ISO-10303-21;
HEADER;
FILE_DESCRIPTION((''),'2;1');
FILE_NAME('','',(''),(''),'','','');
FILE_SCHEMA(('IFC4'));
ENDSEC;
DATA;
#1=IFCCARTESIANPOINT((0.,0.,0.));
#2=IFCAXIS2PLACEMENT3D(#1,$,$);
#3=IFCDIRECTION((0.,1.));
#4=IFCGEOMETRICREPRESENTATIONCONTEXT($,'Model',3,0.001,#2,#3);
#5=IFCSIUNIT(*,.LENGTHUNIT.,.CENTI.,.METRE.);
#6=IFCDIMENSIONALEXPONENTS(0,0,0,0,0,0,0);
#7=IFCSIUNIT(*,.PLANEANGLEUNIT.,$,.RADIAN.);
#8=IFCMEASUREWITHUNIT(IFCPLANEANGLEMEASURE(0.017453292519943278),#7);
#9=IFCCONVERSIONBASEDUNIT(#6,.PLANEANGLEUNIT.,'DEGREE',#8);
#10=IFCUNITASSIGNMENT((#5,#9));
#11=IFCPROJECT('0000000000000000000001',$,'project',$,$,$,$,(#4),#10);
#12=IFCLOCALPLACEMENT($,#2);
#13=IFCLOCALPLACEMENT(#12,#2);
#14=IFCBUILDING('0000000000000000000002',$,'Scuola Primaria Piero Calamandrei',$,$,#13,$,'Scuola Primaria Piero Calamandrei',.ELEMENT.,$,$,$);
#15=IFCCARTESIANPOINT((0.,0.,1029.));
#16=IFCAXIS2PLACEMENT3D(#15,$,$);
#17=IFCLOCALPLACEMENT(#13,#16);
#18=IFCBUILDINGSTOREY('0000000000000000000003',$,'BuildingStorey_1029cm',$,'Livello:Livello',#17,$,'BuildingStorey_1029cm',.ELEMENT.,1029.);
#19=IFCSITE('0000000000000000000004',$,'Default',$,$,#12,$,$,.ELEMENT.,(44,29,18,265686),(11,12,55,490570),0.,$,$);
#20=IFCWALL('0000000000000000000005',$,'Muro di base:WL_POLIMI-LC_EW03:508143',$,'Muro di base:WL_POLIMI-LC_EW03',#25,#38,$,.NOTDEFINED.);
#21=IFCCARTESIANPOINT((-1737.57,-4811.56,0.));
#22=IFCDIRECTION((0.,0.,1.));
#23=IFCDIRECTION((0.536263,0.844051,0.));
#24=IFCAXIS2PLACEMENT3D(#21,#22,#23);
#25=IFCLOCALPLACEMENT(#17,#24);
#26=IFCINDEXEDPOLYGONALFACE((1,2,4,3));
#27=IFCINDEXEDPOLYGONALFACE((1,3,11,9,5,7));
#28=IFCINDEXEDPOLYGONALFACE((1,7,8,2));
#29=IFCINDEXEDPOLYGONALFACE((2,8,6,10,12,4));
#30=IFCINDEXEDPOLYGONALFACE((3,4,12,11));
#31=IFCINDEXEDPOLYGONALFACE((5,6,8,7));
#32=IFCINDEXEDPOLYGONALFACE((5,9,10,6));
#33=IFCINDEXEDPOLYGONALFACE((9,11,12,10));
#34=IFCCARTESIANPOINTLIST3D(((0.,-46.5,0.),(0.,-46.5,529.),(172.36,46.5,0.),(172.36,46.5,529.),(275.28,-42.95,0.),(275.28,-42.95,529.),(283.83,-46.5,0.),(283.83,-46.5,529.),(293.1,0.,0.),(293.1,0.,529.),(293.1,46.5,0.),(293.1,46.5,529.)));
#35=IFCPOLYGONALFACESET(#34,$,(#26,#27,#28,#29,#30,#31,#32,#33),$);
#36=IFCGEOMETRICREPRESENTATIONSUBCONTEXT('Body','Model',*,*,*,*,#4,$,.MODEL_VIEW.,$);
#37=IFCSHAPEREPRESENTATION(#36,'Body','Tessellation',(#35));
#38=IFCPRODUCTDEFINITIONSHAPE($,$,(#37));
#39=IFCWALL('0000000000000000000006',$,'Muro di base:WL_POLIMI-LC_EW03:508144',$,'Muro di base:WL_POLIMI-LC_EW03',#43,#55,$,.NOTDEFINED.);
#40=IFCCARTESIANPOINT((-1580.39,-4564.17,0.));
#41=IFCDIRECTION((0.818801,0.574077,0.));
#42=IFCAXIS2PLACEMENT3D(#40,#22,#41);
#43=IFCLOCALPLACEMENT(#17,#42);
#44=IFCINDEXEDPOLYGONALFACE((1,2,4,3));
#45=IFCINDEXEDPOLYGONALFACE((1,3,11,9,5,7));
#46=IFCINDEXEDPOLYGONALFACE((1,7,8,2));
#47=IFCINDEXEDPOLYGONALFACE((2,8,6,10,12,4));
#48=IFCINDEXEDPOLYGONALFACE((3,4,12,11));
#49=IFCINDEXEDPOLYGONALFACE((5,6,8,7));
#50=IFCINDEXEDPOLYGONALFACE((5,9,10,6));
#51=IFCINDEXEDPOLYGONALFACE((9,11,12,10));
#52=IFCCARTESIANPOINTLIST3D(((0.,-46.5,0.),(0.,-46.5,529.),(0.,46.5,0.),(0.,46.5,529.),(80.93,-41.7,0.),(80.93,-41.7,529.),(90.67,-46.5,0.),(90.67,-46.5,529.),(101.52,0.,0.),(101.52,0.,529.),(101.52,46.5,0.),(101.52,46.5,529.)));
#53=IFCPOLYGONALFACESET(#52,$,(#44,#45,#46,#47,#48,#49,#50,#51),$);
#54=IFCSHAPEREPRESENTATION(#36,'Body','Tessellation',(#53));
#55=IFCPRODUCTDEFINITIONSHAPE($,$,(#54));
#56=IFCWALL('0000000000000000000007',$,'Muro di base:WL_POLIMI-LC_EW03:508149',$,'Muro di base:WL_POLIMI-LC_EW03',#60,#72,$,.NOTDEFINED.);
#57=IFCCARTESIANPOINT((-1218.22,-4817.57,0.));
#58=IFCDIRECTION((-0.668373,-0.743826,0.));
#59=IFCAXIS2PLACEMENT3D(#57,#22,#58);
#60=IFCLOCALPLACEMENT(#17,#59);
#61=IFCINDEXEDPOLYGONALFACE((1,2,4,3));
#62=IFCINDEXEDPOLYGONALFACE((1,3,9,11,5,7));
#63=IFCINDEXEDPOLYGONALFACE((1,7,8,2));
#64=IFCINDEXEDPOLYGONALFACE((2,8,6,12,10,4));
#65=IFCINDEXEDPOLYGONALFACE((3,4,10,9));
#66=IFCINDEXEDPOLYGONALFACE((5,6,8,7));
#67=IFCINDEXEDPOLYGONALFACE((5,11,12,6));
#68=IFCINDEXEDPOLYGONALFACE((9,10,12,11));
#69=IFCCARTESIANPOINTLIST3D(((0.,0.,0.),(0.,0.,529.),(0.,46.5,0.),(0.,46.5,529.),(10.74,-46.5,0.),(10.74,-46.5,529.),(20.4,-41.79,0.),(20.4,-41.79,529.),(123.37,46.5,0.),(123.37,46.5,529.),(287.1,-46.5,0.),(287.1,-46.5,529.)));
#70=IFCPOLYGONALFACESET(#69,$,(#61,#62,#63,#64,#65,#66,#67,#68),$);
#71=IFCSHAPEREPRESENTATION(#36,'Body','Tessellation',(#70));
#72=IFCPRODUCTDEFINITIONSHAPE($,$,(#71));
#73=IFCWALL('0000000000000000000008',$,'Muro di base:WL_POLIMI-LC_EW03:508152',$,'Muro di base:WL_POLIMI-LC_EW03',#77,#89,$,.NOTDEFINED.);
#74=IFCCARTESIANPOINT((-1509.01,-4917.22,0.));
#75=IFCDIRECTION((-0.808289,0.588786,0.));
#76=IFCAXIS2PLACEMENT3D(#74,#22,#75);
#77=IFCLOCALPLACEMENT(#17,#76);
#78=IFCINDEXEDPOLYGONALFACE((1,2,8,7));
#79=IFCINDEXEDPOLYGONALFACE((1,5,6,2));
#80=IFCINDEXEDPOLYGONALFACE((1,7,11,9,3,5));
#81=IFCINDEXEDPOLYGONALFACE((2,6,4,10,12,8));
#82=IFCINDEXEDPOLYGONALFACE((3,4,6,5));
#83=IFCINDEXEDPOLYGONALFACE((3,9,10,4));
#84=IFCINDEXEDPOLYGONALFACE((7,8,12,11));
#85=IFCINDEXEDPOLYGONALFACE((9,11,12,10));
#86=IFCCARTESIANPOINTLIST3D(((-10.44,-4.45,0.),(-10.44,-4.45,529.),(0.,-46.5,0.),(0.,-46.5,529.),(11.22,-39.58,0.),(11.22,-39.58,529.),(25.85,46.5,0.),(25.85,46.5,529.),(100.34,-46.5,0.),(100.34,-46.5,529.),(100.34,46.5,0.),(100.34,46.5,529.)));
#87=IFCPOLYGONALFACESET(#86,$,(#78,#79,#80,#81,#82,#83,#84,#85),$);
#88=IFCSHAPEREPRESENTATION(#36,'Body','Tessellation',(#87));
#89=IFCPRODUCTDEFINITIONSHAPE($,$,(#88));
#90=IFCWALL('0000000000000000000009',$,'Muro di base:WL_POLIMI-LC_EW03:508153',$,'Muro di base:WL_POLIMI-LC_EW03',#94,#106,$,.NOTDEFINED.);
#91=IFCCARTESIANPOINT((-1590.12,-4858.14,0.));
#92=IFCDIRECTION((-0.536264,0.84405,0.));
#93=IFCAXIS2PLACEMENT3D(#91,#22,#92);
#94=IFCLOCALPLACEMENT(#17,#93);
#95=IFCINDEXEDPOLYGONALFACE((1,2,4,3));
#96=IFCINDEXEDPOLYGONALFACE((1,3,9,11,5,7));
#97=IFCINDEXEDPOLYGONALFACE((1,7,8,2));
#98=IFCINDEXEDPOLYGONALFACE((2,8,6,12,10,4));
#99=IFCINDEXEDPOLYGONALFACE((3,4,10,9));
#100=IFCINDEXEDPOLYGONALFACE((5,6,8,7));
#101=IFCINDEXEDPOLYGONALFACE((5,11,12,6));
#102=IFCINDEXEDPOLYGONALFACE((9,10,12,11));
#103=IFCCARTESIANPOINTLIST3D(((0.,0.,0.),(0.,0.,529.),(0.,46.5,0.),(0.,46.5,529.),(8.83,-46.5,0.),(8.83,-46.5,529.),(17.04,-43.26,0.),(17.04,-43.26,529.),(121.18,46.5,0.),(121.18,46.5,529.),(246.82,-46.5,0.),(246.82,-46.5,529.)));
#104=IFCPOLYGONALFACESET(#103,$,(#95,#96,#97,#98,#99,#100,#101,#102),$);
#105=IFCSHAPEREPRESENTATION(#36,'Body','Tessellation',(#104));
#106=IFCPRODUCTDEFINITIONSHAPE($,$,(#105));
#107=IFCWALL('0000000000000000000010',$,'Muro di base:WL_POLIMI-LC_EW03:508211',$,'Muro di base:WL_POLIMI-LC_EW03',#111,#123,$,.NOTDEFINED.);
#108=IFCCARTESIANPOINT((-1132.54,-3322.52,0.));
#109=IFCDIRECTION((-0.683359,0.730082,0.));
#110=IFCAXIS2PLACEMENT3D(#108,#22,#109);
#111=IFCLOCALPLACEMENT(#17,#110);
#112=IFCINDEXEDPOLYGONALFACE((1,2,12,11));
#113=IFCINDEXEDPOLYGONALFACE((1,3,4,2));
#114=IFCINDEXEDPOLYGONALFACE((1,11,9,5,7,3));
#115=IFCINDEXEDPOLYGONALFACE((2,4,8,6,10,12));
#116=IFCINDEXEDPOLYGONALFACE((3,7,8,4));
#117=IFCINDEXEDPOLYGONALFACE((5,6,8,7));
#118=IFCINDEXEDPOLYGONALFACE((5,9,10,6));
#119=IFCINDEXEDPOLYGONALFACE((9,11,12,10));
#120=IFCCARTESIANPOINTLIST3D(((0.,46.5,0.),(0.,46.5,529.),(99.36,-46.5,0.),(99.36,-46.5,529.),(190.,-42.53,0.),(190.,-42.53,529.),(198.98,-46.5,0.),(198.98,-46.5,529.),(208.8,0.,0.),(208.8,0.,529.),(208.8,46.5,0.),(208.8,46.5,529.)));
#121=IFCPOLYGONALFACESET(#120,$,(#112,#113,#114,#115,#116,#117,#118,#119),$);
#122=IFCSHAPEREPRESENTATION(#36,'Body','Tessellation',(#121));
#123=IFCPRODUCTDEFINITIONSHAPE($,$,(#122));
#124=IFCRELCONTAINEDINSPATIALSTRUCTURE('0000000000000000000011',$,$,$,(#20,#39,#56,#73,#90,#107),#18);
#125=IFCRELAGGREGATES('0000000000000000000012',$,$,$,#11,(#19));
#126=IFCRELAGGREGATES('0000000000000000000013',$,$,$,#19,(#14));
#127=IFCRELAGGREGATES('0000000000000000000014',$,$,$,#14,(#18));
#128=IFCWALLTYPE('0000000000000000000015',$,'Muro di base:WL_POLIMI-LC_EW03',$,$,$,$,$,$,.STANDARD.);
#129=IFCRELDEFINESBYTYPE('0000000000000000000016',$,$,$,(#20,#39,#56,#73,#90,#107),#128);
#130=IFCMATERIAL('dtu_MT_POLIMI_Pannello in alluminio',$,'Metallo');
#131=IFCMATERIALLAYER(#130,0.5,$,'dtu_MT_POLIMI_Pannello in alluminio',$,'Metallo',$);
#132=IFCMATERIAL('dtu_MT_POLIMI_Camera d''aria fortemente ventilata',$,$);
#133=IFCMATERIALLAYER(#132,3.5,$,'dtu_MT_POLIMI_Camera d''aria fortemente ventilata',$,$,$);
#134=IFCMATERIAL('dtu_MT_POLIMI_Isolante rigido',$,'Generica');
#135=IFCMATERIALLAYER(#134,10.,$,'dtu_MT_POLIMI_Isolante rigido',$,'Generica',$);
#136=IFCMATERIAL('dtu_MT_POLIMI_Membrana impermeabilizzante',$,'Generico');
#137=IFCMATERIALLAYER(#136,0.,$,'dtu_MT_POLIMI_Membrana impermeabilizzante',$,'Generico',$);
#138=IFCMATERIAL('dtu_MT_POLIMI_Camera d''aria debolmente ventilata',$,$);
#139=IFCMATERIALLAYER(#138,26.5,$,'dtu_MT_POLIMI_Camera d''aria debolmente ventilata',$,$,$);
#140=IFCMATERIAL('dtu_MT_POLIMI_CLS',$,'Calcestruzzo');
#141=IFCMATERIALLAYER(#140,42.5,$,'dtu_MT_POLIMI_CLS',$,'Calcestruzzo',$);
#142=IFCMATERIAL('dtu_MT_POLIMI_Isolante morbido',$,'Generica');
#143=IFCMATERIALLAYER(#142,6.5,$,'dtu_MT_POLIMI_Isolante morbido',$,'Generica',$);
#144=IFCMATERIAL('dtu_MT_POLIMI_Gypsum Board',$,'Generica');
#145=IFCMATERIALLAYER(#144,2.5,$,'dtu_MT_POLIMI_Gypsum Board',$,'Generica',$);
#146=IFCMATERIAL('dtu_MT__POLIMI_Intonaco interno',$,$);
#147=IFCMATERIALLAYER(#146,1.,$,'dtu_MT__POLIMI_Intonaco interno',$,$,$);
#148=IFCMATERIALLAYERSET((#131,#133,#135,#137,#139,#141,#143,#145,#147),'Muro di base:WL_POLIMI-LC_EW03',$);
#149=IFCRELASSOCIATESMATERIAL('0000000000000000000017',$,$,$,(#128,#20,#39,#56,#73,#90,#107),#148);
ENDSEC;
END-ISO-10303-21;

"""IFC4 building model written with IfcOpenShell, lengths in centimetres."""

from ifc_helpers import new_model, entity, si_unit, converted_unit, direction, frame, frame_2d, origin, place, context, subcontext, project, spatial, polyline, rectangle, outline, extrude, clip, bounded_halfspace, material, layer, layer_set, layer_usage, type_object, element, save


model = new_model("IFC4")

# Units and contexts
model_context = context("Model", 3, precision=0.001, world=origin(), true_north=direction((0.0, 1.0)))
body_context = subcontext(model_context, "Body", "Model", "MODEL_VIEW")
ifc_project = project(units=[si_unit("LENGTHUNIT", "METRE", prefix="CENTI"), converted_unit("PLANEANGLEUNIT", "DEGREE", entity("IfcPlaneAngleMeasure", 0.017453292519943278), si_unit("PLANEANGLEUNIT", "RADIAN"), dimensions=[0, 0, 0, 0, 0, 0, 0])], contexts=[model_context])

# Site, building, storey
site_placement = place(None, origin())
site = spatial("IfcSite", under=ifc_project, at=site_placement, Name="Default", CompositionType="ELEMENT", RefLatitude=(44, 29, 18, 265686), RefLongitude=(11, 12, 55, 490570), RefElevation=0.0)
building_placement = place(site_placement, origin())
building = spatial("IfcBuilding", under=site, at=building_placement, Name="Scuola Primaria Piero Calamandrei", LongName="Scuola Primaria Piero Calamandrei", CompositionType="ELEMENT")
storey_placement = place(building_placement, frame((0.0, 0.0, 1029.0)))
storey = spatial("IfcBuildingStorey", under=building, at=storey_placement, Name="BuildingStorey_1029cm", ObjectType="Livello:Livello", LongName="BuildingStorey_1029cm", CompositionType="ELEMENT", Elevation=1029.0)

# Shared definitions
ifc_material_1 = material(Name="dtu_MT_POLIMI_Pannello in alluminio", Category="Metallo")
ifc_material_2 = material(Name="dtu_MT_POLIMI_Camera d'aria fortemente ventilata")
ifc_material_3 = material(Name="dtu_MT_POLIMI_Isolante rigido", Category="Generica")
ifc_material_4 = material(Name="dtu_MT_POLIMI_Membrana impermeabilizzante", Category="Generico")
ifc_material_5 = material(Name="dtu_MT_POLIMI_Camera d'aria debolmente ventilata")
ifc_material_6 = material(Name="dtu_MT_POLIMI_Isolante morbido", Category="Generica")
ifc_material_7 = material(Name="dtu_MT_POLIMI_Gypsum Board", Category="Generica")
ifc_material_8 = material(Name="dtu_MT__POLIMI_Intonaco interno")

# Walls
ifc_layer_1 = layer(ifc_material_1, 0.5, Name="dtu_MT_POLIMI_Pannello in alluminio", Category="Metallo")
ifc_layer_2 = layer(ifc_material_2, 3.5, Name="dtu_MT_POLIMI_Camera d'aria fortemente ventilata")
ifc_layer_3 = layer(ifc_material_3, 10.0, Name="dtu_MT_POLIMI_Isolante rigido", Category="Generica")
ifc_layer_4 = layer(ifc_material_4, 0.0, Name="dtu_MT_POLIMI_Membrana impermeabilizzante", Category="Generico")
ifc_layer_5 = layer(ifc_material_5, 26.5, Name="dtu_MT_POLIMI_Camera d'aria debolmente ventilata")
ifc_material_9 = material(Name="dtu_MT_POLIMI_CLS", Category="Calcestruzzo")
ifc_layer_6 = layer(ifc_material_9, 42.5, Name="dtu_MT_POLIMI_CLS", Category="Calcestruzzo")
ifc_layer_7 = layer(ifc_material_6, 6.5, Name="dtu_MT_POLIMI_Isolante morbido", Category="Generica")
ifc_layer_8 = layer(ifc_material_7, 2.5, Name="dtu_MT_POLIMI_Gypsum Board", Category="Generica")
ifc_layer_9 = layer(ifc_material_8, 1.0, Name="dtu_MT__POLIMI_Intonaco interno")
ifc_layer_set_1 = layer_set([ifc_layer_1, ifc_layer_2, ifc_layer_3, ifc_layer_4, ifc_layer_5, ifc_layer_6, ifc_layer_7, ifc_layer_8, ifc_layer_9], Name="Muro di base:WL_POLIMI-LC_EW03")
ifc_layer_usage_1 = layer_usage(ifc_layer_set_1, "AXIS2", "NEGATIVE", 46.5)
wall_type_1 = type_object("IfcWallType", Name="Muro di base:WL_POLIMI-LC_EW03", PredefinedType="STANDARD", material=ifc_layer_set_1)
wall_1_placement = place(storey_placement, frame((-1737.57, -4811.56, 0.0), z_axis=(0.0, 0.0, 1.0), x_axis=(0.536263, 0.844051, 0.0)))
element("IfcWall", 1, at=wall_1_placement, inside=storey, type_object=wall_type_1, material=ifc_layer_usage_1, Name="Muro di base:WL_POLIMI-LC_EW03:508143", ObjectType="Muro di base:WL_POLIMI-LC_EW03", PredefinedType="NOTDEFINED", context=body_context, shape_type="Clipping", body=[
    clip(clip(extrude(outline(polyline([(172.36, 46.5), (0.0, -46.5), (283.83, -46.5), (275.28, -42.95), (293.1, 0.0), (293.1, 46.5), (172.36, 46.5)])), origin(), (0.0, 0.0, 1.0), 529.0), bounded_halfspace(frame((275.28, -42.95, 0.0), z_axis=(-0.383253, -0.923643, 0.0), x_axis=(0.923643, -0.383253, 0.0)), True, frame((275.28, -42.95, 0.0), z_axis=(-0.383253, -0.923643, 0.0), x_axis=(0.923643, -0.383253, 0.0)), polyline([(0.0, 0.0), (282.38, 0.0), (282.38, 16123.93), (0.0, 16123.93), (0.0, 0.0)]))), bounded_halfspace(frame((275.28, -42.95, 529.0), z_axis=(-0.923643, 0.383253, 0.0), x_axis=(0.383253, 0.923643, 0.0)), True, frame((275.28, -42.95, 529.0), z_axis=(-0.923643, 0.383253, 0.0), x_axis=(0.383253, 0.923643, 0.0)), polyline([(0.0, 0.0), (1417.32, 0.0), (1417.32, 16123.93), (0.0, 16123.93), (0.0, 0.0)]))),
])
ifc_layer_usage_2 = layer_usage(ifc_layer_set_1, "AXIS2", "NEGATIVE", 46.5)
wall_2_placement = place(storey_placement, frame((-1580.39, -4564.17, 0.0), z_axis=(0.0, 0.0, 1.0), x_axis=(0.818801, 0.574077, 0.0)))
element("IfcWall", 2, at=wall_2_placement, inside=storey, type_object=wall_type_1, material=ifc_layer_usage_2, Name="Muro di base:WL_POLIMI-LC_EW03:508144", ObjectType="Muro di base:WL_POLIMI-LC_EW03", PredefinedType="NOTDEFINED", context=body_context, shape_type="Clipping", body=[
    clip(clip(extrude(rectangle(XDim=101.52, YDim=93.0, at=frame_2d((50.76, 0.0), x_axis=(-1.0, 0.0))), origin(), (0.0, 0.0, 1.0), 529.0), bounded_halfspace(frame((80.93, -41.7, 0.0), z_axis=(-0.442682, -0.896679, 0.0), x_axis=(0.896679, -0.442682, 0.0)), True, frame((80.93, -41.7, 0.0), z_axis=(-0.442682, -0.896679, 0.0), x_axis=(0.896679, -0.442682, 0.0)), polyline([(0.0, 0.0), (330.8, 0.0), (330.8, 16123.93), (0.0, 16123.93), (0.0, 0.0)]))), bounded_halfspace(frame((80.93, -41.7, 529.0), z_axis=(-0.896679, 0.442682, 0.0), x_axis=(0.442682, 0.896679, 0.0)), True, frame((80.93, -41.7, 529.0), z_axis=(-0.896679, 0.442682, 0.0), x_axis=(0.442682, 0.896679, 0.0)), polyline([(0.0, 0.0), (1417.32, 0.0), (1417.32, 16123.93), (0.0, 16123.93), (0.0, 0.0)]))),
])

# Walls
ifc_layer_usage_3 = layer_usage(ifc_layer_set_1, "AXIS2", "NEGATIVE", 46.5)
wall_3_placement = place(storey_placement, frame((-1218.22, -4817.57, 0.0), z_axis=(0.0, 0.0, 1.0), x_axis=(-0.668373, -0.743826, 0.0)))
element("IfcWall", 3, at=wall_3_placement, inside=storey, type_object=wall_type_1, material=ifc_layer_usage_3, Name="Muro di base:WL_POLIMI-LC_EW03:508149", ObjectType="Muro di base:WL_POLIMI-LC_EW03", PredefinedType="NOTDEFINED", context=body_context, shape_type="Clipping", body=[
    clip(clip(extrude(outline(polyline([(0.0, 46.5), (0.0, 0.0), (20.4, -41.79), (10.74, -46.5), (98.8, -46.5), (287.1, -46.5), (123.37, 46.5), (0.0, 46.5)])), origin(), (0.0, 0.0, 1.0), 529.0), bounded_halfspace(frame((20.4, -41.79, 529.0), z_axis=(0.438691, -0.898638, 0.0), x_axis=(0.898638, 0.438691, 0.0)), True, frame((20.4, -41.79, 529.0), z_axis=(0.438691, -0.898638, 0.0), x_axis=(0.898638, 0.438691, 0.0)), polyline([(0.0, 0.0), (-327.48, 0.0), (-327.48, -16123.93), (0.0, -16123.93), (0.0, 0.0)]))), bounded_halfspace(frame((20.4, -41.79, 0.0), z_axis=(0.898638, 0.438691, 0.0), x_axis=(-0.438691, 0.898638, 0.0)), True, frame((20.4, -41.79, 0.0), z_axis=(0.898638, 0.438691, 0.0), x_axis=(-0.438691, 0.898638, 0.0)), polyline([(0.0, 0.0), (1417.32, 0.0), (1417.32, 16123.93), (0.0, 16123.93), (0.0, 0.0)]))),
])
ifc_layer_usage_4 = layer_usage(ifc_layer_set_1, "AXIS2", "NEGATIVE", 46.5)
wall_4_placement = place(storey_placement, frame((-1509.01, -4917.22, 0.0), z_axis=(0.0, 0.0, 1.0), x_axis=(-0.808289, 0.588786, 0.0)))
element("IfcWall", 4, at=wall_4_placement, inside=storey, type_object=wall_type_1, material=ifc_layer_usage_4, Name="Muro di base:WL_POLIMI-LC_EW03:508152", ObjectType="Muro di base:WL_POLIMI-LC_EW03", PredefinedType="NOTDEFINED", context=body_context, shape_type="Clipping", body=[
    clip(clip(extrude(outline(polyline([(25.85, 46.5), (-10.44, -4.45), (11.22, -39.58), (0.0, -46.5), (91.51, -46.5), (100.34, -46.5), (100.34, 0.0), (100.34, 46.5), (25.85, 46.5)])), origin(), (0.0, 0.0, 1.0), 529.0), bounded_halfspace(frame((11.22, -39.58, 529.0), z_axis=(0.524953, -0.851131, 0.0), x_axis=(0.851131, 0.524953, 0.0)), True, frame((11.22, -39.58, 529.0), z_axis=(0.524953, -0.851131, 0.0), x_axis=(0.851131, 0.524953, 0.0)), polyline([(0.0, 0.0), (-401.93, 0.0), (-401.93, -16123.93), (0.0, -16123.93), (0.0, 0.0)]))), bounded_halfspace(frame((11.22, -39.58, 0.0), z_axis=(0.851131, 0.524953, 0.0), x_axis=(-0.524953, 0.851131, 0.0)), True, frame((11.22, -39.58, 0.0), z_axis=(0.851131, 0.524953, 0.0), x_axis=(-0.524953, 0.851131, 0.0)), polyline([(0.0, 0.0), (1258.06, 0.0), (1258.06, 16123.93), (0.0, 16123.93), (0.0, 0.0)]))),
])
ifc_layer_usage_5 = layer_usage(ifc_layer_set_1, "AXIS2", "NEGATIVE", 46.5)
wall_5_placement = place(storey_placement, frame((-1590.12, -4858.14, 0.0), z_axis=(0.0, 0.0, 1.0), x_axis=(-0.536264, 0.84405, 0.0)))
element("IfcWall", 5, at=wall_5_placement, inside=storey, type_object=wall_type_1, material=ifc_layer_usage_5, Name="Muro di base:WL_POLIMI-LC_EW03:508153", ObjectType="Muro di base:WL_POLIMI-LC_EW03", PredefinedType="NOTDEFINED", context=body_context, shape_type="Clipping", body=[
    clip(clip(extrude(outline(polyline([(0.0, 46.5), (0.0, 0.0), (17.04, -43.26), (8.83, -46.5), (246.82, -46.5), (121.18, 46.5), (0.0, 46.5)])), origin(), (0.0, 0.0, 1.0), 529.0), bounded_halfspace(frame((17.04, -43.26, 529.0), z_axis=(0.366492, -0.930421, 0.0), x_axis=(0.930421, 0.366492, 0.0)), True, frame((17.04, -43.26, 529.0), z_axis=(0.366492, -0.930421, 0.0), x_axis=(0.930421, 0.366492, 0.0)), polyline([(0.0, 0.0), (-269.08, 0.0), (-269.08, -16123.93), (0.0, -16123.93), (0.0, 0.0)]))), bounded_halfspace(frame((17.04, -43.26, 0.0), z_axis=(0.930421, 0.366492, 0.0), x_axis=(-0.366492, 0.930421, 0.0)), True, frame((17.04, -43.26, 0.0), z_axis=(0.930421, 0.366492, 0.0), x_axis=(-0.366492, 0.930421, 0.0)), polyline([(0.0, 0.0), (1417.32, 0.0), (1417.32, 16123.93), (0.0, 16123.93), (0.0, 0.0)]))),
])
ifc_layer_usage_6 = layer_usage(ifc_layer_set_1, "AXIS2", "NEGATIVE", 46.5)
wall_6_placement = place(storey_placement, frame((-1132.54, -3322.52, 0.0), z_axis=(0.0, 0.0, 1.0), x_axis=(-0.683359, 0.730082, 0.0)))
element("IfcWall", 6, at=wall_6_placement, inside=storey, type_object=wall_type_1, material=ifc_layer_usage_6, Name="Muro di base:WL_POLIMI-LC_EW03:508211", ObjectType="Muro di base:WL_POLIMI-LC_EW03", PredefinedType="NOTDEFINED", context=body_context, shape_type="Clipping", body=[
    clip(clip(extrude(outline(polyline([(0.0, 46.5), (99.36, -46.5), (198.98, -46.5), (190.0, -42.53), (208.8, 0.0), (208.8, 46.5), (0.0, 46.5)])), origin(), (0.0, 0.0, 1.0), 529.0), bounded_halfspace(frame((190.0, -42.53, 0.0), z_axis=(-0.404268, -0.914641, 0.0), x_axis=(0.914641, -0.404268, 0.0)), True, frame((190.0, -42.53, 0.0), z_axis=(-0.404268, -0.914641, 0.0), x_axis=(0.914641, -0.404268, 0.0)), polyline([(0.0, 0.0), (299.26, 0.0), (299.26, 16123.93), (0.0, 16123.93), (0.0, 0.0)]))), bounded_halfspace(frame((190.0, -42.53, 529.0), z_axis=(-0.914641, 0.404268, 0.0), x_axis=(0.404268, 0.914641, 0.0)), True, frame((190.0, -42.53, 529.0), z_axis=(-0.914641, 0.404268, 0.0), x_axis=(0.404268, 0.914641, 0.0)), polyline([(0.0, 0.0), (1417.32, 0.0), (1417.32, 16123.93), (0.0, 16123.93), (0.0, 0.0)]))),
])

save(model, "model.ifc")
